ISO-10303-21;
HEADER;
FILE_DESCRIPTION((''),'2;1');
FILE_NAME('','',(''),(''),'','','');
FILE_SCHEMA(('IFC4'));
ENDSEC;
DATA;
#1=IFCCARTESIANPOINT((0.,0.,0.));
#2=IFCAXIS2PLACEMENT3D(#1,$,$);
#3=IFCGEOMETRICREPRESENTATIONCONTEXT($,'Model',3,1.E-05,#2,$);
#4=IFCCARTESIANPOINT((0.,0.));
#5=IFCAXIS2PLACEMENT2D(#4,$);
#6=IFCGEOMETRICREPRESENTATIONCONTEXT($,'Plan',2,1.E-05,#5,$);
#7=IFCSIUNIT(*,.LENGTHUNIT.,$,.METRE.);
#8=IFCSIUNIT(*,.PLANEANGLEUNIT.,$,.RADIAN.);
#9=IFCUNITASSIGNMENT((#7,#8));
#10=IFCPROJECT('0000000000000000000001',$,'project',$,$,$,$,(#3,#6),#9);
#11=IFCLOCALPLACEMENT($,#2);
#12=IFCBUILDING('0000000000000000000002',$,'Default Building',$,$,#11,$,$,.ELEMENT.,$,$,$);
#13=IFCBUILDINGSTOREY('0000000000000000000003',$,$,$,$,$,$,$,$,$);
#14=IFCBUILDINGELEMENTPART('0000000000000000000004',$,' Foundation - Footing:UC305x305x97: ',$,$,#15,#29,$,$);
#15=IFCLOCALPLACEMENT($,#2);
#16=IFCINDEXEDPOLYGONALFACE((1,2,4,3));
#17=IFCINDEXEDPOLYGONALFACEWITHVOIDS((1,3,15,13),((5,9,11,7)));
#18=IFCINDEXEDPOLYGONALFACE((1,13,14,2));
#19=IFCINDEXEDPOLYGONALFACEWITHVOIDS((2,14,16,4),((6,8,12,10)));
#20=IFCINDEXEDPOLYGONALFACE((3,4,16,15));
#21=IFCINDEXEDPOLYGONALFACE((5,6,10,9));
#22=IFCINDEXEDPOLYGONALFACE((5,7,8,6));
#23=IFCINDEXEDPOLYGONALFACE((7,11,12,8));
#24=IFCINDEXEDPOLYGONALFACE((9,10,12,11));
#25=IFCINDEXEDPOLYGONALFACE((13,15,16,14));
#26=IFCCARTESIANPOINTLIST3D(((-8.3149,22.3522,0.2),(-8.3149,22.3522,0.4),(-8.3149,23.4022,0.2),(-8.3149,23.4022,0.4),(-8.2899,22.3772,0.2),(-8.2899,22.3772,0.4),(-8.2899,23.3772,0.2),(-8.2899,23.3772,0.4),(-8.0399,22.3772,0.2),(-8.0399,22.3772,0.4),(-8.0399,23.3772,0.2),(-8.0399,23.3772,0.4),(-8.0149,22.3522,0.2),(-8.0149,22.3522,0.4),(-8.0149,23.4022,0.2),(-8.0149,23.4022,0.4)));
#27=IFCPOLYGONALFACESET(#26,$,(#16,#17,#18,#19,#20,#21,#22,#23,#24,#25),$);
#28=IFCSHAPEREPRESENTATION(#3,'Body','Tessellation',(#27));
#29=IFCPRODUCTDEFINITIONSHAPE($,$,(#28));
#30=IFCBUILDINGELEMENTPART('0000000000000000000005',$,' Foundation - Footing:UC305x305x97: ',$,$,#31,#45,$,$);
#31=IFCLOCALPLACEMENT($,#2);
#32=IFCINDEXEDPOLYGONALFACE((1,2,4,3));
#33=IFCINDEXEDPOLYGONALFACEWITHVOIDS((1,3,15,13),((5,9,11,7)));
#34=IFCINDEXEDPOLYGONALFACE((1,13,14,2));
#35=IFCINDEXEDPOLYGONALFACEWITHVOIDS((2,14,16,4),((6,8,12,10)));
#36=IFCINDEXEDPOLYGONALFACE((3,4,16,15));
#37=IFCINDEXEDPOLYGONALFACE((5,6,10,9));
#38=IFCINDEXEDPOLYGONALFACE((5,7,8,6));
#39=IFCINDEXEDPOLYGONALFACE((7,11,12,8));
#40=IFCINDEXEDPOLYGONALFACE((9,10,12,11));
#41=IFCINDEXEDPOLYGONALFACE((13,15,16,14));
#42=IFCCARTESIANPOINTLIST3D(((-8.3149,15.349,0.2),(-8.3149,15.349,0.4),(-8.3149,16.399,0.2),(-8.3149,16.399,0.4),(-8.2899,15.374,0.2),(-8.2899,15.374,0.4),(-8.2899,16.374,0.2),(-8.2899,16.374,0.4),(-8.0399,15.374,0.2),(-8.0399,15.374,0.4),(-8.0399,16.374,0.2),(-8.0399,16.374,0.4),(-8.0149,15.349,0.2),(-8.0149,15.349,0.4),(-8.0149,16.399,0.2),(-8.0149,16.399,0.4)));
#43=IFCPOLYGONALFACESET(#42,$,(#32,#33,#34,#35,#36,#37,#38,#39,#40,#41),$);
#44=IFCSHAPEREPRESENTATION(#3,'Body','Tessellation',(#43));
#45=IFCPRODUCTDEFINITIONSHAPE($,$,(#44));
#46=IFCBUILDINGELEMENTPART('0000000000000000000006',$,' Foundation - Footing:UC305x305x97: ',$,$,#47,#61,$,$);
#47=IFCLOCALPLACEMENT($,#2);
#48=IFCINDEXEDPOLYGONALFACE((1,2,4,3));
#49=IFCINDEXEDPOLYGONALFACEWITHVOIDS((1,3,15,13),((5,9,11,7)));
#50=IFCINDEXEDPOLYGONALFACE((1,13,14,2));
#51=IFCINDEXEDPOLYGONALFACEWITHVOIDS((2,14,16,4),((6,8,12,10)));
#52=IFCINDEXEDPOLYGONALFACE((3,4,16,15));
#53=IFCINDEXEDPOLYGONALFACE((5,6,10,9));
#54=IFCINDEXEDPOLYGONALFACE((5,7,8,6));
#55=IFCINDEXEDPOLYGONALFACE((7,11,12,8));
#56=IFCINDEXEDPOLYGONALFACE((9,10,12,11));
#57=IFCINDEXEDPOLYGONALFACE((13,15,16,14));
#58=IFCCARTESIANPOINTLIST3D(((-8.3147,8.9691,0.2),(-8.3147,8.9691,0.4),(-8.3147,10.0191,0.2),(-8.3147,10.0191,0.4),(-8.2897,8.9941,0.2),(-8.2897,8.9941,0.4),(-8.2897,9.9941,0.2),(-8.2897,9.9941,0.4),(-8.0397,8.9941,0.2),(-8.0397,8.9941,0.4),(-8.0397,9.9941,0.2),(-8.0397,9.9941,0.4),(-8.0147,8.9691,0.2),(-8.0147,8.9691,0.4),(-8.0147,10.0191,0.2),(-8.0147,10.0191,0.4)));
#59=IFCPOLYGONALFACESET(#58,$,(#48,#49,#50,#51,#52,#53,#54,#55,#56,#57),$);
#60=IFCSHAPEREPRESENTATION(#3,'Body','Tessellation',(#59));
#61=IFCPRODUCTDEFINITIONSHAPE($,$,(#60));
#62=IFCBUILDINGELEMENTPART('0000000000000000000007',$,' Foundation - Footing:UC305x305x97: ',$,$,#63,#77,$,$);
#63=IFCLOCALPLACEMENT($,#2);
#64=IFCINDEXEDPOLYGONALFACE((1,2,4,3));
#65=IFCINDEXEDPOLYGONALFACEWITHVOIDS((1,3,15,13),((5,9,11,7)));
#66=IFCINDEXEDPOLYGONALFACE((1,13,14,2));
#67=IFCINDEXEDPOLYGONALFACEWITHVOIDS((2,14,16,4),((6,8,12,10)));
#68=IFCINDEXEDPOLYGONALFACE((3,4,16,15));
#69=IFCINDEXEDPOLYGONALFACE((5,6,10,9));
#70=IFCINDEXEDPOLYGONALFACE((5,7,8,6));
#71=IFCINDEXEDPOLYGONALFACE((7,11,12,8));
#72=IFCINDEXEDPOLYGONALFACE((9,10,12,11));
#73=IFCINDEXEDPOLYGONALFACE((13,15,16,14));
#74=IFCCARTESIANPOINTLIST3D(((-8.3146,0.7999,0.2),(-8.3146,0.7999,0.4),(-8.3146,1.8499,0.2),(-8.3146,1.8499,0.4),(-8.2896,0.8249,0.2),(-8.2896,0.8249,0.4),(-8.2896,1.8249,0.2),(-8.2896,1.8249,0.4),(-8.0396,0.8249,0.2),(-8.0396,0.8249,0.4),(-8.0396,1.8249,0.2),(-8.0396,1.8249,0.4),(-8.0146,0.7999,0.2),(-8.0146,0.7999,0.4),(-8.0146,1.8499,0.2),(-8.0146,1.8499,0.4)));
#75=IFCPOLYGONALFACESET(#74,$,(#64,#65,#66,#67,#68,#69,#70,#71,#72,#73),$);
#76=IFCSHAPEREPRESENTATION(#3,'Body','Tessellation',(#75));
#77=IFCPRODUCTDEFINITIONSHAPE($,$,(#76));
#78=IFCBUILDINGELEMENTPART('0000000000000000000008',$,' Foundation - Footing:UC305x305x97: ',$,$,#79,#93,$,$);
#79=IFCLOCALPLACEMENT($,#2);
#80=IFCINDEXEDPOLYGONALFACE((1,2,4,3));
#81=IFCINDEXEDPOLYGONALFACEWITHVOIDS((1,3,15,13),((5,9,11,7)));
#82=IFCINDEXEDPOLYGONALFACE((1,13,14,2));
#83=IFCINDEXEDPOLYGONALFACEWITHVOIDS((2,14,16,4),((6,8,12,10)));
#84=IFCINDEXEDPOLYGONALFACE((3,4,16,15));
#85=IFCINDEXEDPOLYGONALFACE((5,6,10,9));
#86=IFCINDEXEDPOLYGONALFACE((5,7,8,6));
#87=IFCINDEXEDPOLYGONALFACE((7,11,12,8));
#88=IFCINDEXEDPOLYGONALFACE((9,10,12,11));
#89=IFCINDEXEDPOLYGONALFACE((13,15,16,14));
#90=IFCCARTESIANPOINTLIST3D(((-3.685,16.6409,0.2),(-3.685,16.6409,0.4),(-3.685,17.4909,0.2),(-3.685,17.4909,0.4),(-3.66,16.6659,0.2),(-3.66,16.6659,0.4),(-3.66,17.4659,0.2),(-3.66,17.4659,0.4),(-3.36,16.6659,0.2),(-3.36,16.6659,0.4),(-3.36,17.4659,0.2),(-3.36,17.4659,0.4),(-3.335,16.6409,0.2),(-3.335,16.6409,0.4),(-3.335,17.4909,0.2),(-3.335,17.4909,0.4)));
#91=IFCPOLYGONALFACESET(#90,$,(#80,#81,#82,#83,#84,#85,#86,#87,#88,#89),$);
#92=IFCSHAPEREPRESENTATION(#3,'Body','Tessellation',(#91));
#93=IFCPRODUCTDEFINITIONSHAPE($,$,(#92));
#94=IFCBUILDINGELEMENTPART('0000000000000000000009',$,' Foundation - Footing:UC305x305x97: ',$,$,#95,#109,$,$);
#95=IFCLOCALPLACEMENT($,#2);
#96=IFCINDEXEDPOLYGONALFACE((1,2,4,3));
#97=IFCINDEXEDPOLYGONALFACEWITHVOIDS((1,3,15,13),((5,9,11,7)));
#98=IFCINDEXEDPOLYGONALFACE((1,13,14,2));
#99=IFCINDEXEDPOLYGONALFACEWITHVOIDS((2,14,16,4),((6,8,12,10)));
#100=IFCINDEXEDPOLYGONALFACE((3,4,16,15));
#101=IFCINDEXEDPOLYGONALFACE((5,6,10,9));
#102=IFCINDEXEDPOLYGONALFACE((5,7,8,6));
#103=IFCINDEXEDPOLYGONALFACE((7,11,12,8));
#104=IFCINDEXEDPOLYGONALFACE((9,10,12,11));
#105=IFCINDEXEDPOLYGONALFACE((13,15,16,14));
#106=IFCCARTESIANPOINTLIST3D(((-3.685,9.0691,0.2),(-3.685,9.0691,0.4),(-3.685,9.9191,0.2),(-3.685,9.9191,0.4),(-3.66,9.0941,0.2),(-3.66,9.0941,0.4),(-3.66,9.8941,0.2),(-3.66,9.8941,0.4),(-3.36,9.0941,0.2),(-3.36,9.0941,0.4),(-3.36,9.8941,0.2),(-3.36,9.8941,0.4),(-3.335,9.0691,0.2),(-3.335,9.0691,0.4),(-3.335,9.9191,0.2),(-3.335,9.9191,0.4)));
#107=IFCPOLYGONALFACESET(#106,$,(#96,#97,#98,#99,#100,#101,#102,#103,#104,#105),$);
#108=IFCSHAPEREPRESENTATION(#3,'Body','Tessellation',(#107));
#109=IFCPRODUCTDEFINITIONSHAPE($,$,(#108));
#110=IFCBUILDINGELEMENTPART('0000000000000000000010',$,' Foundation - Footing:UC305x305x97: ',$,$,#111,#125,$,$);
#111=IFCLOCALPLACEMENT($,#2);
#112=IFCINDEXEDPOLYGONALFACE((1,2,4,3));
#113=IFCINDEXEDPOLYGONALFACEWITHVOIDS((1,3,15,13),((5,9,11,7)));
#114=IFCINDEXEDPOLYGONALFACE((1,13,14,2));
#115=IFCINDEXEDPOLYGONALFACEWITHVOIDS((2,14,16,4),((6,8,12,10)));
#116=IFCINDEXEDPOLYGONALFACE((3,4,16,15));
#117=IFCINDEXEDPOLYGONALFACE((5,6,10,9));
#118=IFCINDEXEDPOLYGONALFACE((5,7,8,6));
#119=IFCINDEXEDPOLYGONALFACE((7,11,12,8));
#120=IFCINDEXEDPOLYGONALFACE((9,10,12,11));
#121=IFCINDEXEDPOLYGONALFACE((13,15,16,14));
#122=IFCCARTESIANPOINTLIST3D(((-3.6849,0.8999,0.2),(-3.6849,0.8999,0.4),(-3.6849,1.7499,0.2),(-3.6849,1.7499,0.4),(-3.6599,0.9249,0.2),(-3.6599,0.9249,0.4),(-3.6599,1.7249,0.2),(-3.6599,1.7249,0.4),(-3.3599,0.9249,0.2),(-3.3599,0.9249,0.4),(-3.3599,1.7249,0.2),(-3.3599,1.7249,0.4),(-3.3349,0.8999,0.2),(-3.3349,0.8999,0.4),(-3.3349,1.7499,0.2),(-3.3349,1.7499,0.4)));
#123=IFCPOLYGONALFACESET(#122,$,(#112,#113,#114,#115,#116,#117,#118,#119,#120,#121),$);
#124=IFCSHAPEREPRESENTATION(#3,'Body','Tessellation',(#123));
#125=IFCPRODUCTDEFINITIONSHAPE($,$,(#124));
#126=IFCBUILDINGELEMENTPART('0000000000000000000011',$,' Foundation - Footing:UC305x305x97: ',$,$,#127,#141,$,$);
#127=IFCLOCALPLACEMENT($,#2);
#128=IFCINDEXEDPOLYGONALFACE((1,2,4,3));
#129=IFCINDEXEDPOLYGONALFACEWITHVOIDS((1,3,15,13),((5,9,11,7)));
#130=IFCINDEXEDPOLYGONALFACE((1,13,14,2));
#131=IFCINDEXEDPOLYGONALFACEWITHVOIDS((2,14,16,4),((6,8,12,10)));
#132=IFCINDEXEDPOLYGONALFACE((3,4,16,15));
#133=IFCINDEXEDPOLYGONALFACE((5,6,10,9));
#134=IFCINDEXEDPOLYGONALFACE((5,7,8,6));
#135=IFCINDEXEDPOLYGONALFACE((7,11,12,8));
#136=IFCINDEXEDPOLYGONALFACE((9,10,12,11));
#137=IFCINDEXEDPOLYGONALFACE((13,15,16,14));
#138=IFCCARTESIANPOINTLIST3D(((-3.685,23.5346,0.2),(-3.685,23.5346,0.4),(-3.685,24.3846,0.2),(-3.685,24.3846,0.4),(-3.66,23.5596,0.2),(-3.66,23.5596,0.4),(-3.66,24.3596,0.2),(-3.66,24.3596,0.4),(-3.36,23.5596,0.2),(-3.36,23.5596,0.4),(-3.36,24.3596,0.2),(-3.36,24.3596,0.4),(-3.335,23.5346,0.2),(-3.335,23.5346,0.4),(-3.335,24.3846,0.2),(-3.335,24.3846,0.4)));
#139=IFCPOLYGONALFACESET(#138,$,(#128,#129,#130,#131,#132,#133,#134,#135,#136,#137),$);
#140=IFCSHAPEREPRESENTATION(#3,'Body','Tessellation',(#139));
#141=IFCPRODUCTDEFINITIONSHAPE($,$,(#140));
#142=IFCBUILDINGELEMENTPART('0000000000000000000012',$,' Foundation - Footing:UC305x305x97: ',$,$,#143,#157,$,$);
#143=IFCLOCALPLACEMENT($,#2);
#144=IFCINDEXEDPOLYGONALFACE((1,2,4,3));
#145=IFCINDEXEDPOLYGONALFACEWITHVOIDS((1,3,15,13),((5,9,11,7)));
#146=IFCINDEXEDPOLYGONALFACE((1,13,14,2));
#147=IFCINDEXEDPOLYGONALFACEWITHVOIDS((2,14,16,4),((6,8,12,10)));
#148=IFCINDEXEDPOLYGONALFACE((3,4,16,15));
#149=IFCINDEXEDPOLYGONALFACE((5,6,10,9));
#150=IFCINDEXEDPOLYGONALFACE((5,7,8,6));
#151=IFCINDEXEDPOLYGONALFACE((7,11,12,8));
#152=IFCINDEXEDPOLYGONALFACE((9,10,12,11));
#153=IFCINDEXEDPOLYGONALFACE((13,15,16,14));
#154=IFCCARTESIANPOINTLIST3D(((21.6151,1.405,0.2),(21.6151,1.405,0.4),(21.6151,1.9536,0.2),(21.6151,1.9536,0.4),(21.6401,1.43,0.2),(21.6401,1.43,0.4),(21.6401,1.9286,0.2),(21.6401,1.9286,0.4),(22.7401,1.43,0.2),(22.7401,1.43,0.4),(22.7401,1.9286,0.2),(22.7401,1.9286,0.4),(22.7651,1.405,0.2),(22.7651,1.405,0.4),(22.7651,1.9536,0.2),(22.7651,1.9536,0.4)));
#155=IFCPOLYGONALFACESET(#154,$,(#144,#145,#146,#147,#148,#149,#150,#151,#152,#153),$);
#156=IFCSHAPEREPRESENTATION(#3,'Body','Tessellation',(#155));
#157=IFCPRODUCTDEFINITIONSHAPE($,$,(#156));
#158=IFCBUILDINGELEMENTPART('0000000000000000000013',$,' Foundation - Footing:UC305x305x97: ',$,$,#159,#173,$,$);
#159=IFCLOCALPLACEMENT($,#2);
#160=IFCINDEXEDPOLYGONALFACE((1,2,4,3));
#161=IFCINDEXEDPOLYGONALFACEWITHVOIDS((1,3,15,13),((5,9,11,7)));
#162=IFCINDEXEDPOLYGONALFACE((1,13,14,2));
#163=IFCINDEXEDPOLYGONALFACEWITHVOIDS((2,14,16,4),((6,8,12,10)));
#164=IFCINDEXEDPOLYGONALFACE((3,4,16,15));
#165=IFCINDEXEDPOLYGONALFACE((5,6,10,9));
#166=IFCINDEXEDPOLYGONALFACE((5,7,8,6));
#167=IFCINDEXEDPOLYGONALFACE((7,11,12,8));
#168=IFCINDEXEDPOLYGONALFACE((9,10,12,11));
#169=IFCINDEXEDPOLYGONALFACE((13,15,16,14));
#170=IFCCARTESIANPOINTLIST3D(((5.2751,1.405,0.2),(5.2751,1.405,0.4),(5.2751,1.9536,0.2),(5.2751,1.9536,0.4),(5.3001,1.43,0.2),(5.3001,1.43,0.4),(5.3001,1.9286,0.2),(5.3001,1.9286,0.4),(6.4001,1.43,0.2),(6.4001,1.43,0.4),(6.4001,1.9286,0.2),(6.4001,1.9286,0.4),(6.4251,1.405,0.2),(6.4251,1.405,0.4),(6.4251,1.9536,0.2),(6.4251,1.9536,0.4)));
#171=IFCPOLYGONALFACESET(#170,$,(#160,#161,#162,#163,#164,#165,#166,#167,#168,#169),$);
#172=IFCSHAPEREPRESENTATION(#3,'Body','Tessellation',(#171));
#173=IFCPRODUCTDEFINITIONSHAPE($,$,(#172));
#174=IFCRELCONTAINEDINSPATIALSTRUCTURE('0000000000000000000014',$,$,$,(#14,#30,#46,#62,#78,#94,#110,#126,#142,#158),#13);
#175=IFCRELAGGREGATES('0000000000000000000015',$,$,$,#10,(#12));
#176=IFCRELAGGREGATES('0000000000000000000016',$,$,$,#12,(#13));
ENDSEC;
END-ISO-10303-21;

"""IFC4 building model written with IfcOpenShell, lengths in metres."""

from ifc_helpers import new_model, si_unit, origin, origin_2d, place, context, project, spatial, polyline, outline, extrude, element, save


model = new_model("IFC4")

# Units and contexts
model_context = context("Model", 3, precision=1e-05, world=origin())
plan_context = context("Plan", 2, precision=1e-05, world=origin_2d())
ifc_project = project(units=[si_unit("LENGTHUNIT", "METRE"), si_unit("PLANEANGLEUNIT", "RADIAN")], contexts=[model_context, plan_context])

# Building, storey
building_placement = place(None, origin())
building = spatial("IfcBuilding", under=ifc_project, at=building_placement, Name="Default Building", CompositionType="ELEMENT")
storey = spatial("IfcBuildingStorey", under=building)

# Building element parts, openings
building_element_part_1 = element("IfcBuildingElementPart", 1, inside=storey, Name=" Foundation - Footing:UC305x305x97: ", context=model_context, shape_type="SweptSolid", body=[
    extrude(outline(polyline([(-8.0149, 23.4022, 0.2), (-8.3149, 23.4022, 0.2), (-8.3149, 22.3522, 0.2), (-8.0149, 22.3522, 0.2), (-8.0149, 23.4022, 0.2)])), None, (0.0, 0.0, 1.0), 0.2),
])
element("IfcOpeningElement", 2, inside=storey, cuts=building_element_part_1, context=model_context, shape_type="SweptSolid", body=[
    extrude(outline(polyline([(-8.0399, 23.3772, 0.2), (-8.2899, 23.3772, 0.2), (-8.2899, 22.3772, 0.2), (-8.0399, 22.3772, 0.2), (-8.0399, 23.3772, 0.2)])), None, (0.0, 0.0, 1.0), 0.2),
])
building_element_part_2 = element("IfcBuildingElementPart", 3, inside=storey, Name=" Foundation - Footing:UC305x305x97: ", context=model_context, shape_type="SweptSolid", body=[
    extrude(outline(polyline([(-8.0149, 16.399, 0.2), (-8.3149, 16.399, 0.2), (-8.3149, 15.349, 0.2), (-8.0149, 15.349, 0.2), (-8.0149, 16.399, 0.2)])), None, (0.0, 0.0, 1.0), 0.2),
])
element("IfcOpeningElement", 4, inside=storey, cuts=building_element_part_2, context=model_context, shape_type="SweptSolid", body=[
    extrude(outline(polyline([(-8.0399, 16.374, 0.2), (-8.2899, 16.374, 0.2), (-8.2899, 15.374, 0.2), (-8.0399, 15.374, 0.2), (-8.0399, 16.374, 0.2)])), None, (0.0, 0.0, 1.0), 0.2),
])
building_element_part_3 = element("IfcBuildingElementPart", 5, inside=storey, Name=" Foundation - Footing:UC305x305x97: ", context=model_context, shape_type="SweptSolid", body=[
    extrude(outline(polyline([(-8.0147, 10.0191, 0.2), (-8.3147, 10.0191, 0.2), (-8.3147, 8.9691, 0.2), (-8.0147, 8.9691, 0.2), (-8.0147, 10.0191, 0.2)])), None, (0.0, 0.0, 1.0), 0.2),
])
element("IfcOpeningElement", 6, inside=storey, cuts=building_element_part_3, context=model_context, shape_type="SweptSolid", body=[
    extrude(outline(polyline([(-8.0397, 9.9941, 0.2), (-8.2897, 9.9941, 0.2), (-8.2897, 8.9941, 0.2), (-8.0397, 8.9941, 0.2), (-8.0397, 9.9941, 0.2)])), None, (0.0, 0.0, 1.0), 0.2),
])
building_element_part_4 = element("IfcBuildingElementPart", 7, inside=storey, Name=" Foundation - Footing:UC305x305x97: ", context=model_context, shape_type="SweptSolid", body=[
    extrude(outline(polyline([(-8.0146, 1.8499, 0.2), (-8.3146, 1.8499, 0.2), (-8.3146, 0.7999, 0.2), (-8.0146, 0.7999, 0.2), (-8.0146, 1.8499, 0.2)])), None, (0.0, 0.0, 1.0), 0.2),
])
element("IfcOpeningElement", 8, inside=storey, cuts=building_element_part_4, context=model_context, shape_type="SweptSolid", body=[
    extrude(outline(polyline([(-8.0396, 1.8249, 0.2), (-8.2896, 1.8249, 0.2), (-8.2896, 0.8249, 0.2), (-8.0396, 0.8249, 0.2), (-8.0396, 1.8249, 0.2)])), None, (0.0, 0.0, 1.0), 0.2),
])
building_element_part_5 = element("IfcBuildingElementPart", 9, inside=storey, Name=" Foundation - Footing:UC305x305x97: ", context=model_context, shape_type="SweptSolid", body=[
    extrude(outline(polyline([(-3.335, 17.4909, 0.2), (-3.685, 17.4909, 0.2), (-3.685, 16.6409, 0.2), (-3.335, 16.6409, 0.2), (-3.335, 17.4909, 0.2)])), None, (0.0, 0.0, 1.0), 0.2),
])
element("IfcOpeningElement", 10, inside=storey, cuts=building_element_part_5, context=model_context, shape_type="SweptSolid", body=[
    extrude(outline(polyline([(-3.36, 17.4659, 0.2), (-3.66, 17.4659, 0.2), (-3.66, 16.6659, 0.2), (-3.36, 16.6659, 0.2), (-3.36, 17.4659, 0.2)])), None, (0.0, 0.0, 1.0), 0.2),
])
building_element_part_6 = element("IfcBuildingElementPart", 11, inside=storey, Name=" Foundation - Footing:UC305x305x97: ", context=model_context, shape_type="SweptSolid", body=[
    extrude(outline(polyline([(-3.335, 9.9191, 0.2), (-3.685, 9.9191, 0.2), (-3.685, 9.0691, 0.2), (-3.335, 9.0691, 0.2), (-3.335, 9.9191, 0.2)])), None, (0.0, 0.0, 1.0), 0.2),
])
element("IfcOpeningElement", 12, inside=storey, cuts=building_element_part_6, context=model_context, shape_type="SweptSolid", body=[
    extrude(outline(polyline([(-3.36, 9.8941, 0.2), (-3.66, 9.8941, 0.2), (-3.66, 9.0941, 0.2), (-3.36, 9.0941, 0.2), (-3.36, 9.8941, 0.2)])), None, (0.0, 0.0, 1.0), 0.2),
])
building_element_part_7 = element("IfcBuildingElementPart", 13, inside=storey, Name=" Foundation - Footing:UC305x305x97: ", context=model_context, shape_type="SweptSolid", body=[
    extrude(outline(polyline([(-3.3349, 1.7499, 0.2), (-3.6849, 1.7499, 0.2), (-3.6849, 0.8999, 0.2), (-3.3349, 0.8999, 0.2), (-3.3349, 1.7499, 0.2)])), None, (0.0, 0.0, 1.0), 0.2),
])
element("IfcOpeningElement", 14, inside=storey, cuts=building_element_part_7, context=model_context, shape_type="SweptSolid", body=[
    extrude(outline(polyline([(-3.3599, 1.7249, 0.2), (-3.6599, 1.7249, 0.2), (-3.6599, 0.9249, 0.2), (-3.3599, 0.9249, 0.2), (-3.3599, 1.7249, 0.2)])), None, (0.0, 0.0, 1.0), 0.2),
])
building_element_part_8 = element("IfcBuildingElementPart", 15, inside=storey, Name=" Foundation - Footing:UC305x305x97: ", context=model_context, shape_type="SweptSolid", body=[
    extrude(outline(polyline([(-3.685, 23.5346, 0.2), (-3.335, 23.5346, 0.2), (-3.335, 24.3846, 0.2), (-3.685, 24.3846, 0.2), (-3.685, 23.5346, 0.2)])), None, (0.0, 0.0, 1.0), 0.2),
])
element("IfcOpeningElement", 16, inside=storey, cuts=building_element_part_8, context=model_context, shape_type="SweptSolid", body=[
    extrude(outline(polyline([(-3.66, 23.5596, 0.2), (-3.36, 23.5596, 0.2), (-3.36, 24.3596, 0.2), (-3.66, 24.3596, 0.2), (-3.66, 23.5596, 0.2)])), None, (0.0, 0.0, 1.0), 0.2),
])
building_element_part_9 = element("IfcBuildingElementPart", 17, inside=storey, Name=" Foundation - Footing:UC305x305x97: ", context=model_context, shape_type="SweptSolid", body=[
    extrude(outline(polyline([(21.6151, 1.405, 0.2), (22.7651, 1.405, 0.2), (22.7651, 1.9536, 0.2), (21.6151, 1.9536, 0.2), (21.6151, 1.405, 0.2)])), None, (0.0, 0.0, 1.0), 0.2),
])
element("IfcOpeningElement", 18, inside=storey, cuts=building_element_part_9, context=model_context, shape_type="SweptSolid", body=[
    extrude(outline(polyline([(21.6401, 1.43, 0.2), (22.7401, 1.43, 0.2), (22.7401, 1.9286, 0.2), (21.6401, 1.9286, 0.2), (21.6401, 1.43, 0.2)])), None, (0.0, 0.0, 1.0), 0.2),
])
building_element_part_10 = element("IfcBuildingElementPart", 19, inside=storey, Name=" Foundation - Footing:UC305x305x97: ", context=model_context, shape_type="SweptSolid", body=[
    extrude(outline(polyline([(5.2751, 1.405, 0.2), (6.4251, 1.405, 0.2), (6.4251, 1.9536, 0.2), (5.2751, 1.9536, 0.2), (5.2751, 1.405, 0.2)])), None, (0.0, 0.0, 1.0), 0.2),
])
element("IfcOpeningElement", 20, inside=storey, cuts=building_element_part_10, context=model_context, shape_type="SweptSolid", body=[
    extrude(outline(polyline([(5.3001, 1.43, 0.2), (6.4001, 1.43, 0.2), (6.4001, 1.9286, 0.2), (5.3001, 1.9286, 0.2), (5.3001, 1.43, 0.2)])), None, (0.0, 0.0, 1.0), 0.2),
])

save(model, "model.ifc")
